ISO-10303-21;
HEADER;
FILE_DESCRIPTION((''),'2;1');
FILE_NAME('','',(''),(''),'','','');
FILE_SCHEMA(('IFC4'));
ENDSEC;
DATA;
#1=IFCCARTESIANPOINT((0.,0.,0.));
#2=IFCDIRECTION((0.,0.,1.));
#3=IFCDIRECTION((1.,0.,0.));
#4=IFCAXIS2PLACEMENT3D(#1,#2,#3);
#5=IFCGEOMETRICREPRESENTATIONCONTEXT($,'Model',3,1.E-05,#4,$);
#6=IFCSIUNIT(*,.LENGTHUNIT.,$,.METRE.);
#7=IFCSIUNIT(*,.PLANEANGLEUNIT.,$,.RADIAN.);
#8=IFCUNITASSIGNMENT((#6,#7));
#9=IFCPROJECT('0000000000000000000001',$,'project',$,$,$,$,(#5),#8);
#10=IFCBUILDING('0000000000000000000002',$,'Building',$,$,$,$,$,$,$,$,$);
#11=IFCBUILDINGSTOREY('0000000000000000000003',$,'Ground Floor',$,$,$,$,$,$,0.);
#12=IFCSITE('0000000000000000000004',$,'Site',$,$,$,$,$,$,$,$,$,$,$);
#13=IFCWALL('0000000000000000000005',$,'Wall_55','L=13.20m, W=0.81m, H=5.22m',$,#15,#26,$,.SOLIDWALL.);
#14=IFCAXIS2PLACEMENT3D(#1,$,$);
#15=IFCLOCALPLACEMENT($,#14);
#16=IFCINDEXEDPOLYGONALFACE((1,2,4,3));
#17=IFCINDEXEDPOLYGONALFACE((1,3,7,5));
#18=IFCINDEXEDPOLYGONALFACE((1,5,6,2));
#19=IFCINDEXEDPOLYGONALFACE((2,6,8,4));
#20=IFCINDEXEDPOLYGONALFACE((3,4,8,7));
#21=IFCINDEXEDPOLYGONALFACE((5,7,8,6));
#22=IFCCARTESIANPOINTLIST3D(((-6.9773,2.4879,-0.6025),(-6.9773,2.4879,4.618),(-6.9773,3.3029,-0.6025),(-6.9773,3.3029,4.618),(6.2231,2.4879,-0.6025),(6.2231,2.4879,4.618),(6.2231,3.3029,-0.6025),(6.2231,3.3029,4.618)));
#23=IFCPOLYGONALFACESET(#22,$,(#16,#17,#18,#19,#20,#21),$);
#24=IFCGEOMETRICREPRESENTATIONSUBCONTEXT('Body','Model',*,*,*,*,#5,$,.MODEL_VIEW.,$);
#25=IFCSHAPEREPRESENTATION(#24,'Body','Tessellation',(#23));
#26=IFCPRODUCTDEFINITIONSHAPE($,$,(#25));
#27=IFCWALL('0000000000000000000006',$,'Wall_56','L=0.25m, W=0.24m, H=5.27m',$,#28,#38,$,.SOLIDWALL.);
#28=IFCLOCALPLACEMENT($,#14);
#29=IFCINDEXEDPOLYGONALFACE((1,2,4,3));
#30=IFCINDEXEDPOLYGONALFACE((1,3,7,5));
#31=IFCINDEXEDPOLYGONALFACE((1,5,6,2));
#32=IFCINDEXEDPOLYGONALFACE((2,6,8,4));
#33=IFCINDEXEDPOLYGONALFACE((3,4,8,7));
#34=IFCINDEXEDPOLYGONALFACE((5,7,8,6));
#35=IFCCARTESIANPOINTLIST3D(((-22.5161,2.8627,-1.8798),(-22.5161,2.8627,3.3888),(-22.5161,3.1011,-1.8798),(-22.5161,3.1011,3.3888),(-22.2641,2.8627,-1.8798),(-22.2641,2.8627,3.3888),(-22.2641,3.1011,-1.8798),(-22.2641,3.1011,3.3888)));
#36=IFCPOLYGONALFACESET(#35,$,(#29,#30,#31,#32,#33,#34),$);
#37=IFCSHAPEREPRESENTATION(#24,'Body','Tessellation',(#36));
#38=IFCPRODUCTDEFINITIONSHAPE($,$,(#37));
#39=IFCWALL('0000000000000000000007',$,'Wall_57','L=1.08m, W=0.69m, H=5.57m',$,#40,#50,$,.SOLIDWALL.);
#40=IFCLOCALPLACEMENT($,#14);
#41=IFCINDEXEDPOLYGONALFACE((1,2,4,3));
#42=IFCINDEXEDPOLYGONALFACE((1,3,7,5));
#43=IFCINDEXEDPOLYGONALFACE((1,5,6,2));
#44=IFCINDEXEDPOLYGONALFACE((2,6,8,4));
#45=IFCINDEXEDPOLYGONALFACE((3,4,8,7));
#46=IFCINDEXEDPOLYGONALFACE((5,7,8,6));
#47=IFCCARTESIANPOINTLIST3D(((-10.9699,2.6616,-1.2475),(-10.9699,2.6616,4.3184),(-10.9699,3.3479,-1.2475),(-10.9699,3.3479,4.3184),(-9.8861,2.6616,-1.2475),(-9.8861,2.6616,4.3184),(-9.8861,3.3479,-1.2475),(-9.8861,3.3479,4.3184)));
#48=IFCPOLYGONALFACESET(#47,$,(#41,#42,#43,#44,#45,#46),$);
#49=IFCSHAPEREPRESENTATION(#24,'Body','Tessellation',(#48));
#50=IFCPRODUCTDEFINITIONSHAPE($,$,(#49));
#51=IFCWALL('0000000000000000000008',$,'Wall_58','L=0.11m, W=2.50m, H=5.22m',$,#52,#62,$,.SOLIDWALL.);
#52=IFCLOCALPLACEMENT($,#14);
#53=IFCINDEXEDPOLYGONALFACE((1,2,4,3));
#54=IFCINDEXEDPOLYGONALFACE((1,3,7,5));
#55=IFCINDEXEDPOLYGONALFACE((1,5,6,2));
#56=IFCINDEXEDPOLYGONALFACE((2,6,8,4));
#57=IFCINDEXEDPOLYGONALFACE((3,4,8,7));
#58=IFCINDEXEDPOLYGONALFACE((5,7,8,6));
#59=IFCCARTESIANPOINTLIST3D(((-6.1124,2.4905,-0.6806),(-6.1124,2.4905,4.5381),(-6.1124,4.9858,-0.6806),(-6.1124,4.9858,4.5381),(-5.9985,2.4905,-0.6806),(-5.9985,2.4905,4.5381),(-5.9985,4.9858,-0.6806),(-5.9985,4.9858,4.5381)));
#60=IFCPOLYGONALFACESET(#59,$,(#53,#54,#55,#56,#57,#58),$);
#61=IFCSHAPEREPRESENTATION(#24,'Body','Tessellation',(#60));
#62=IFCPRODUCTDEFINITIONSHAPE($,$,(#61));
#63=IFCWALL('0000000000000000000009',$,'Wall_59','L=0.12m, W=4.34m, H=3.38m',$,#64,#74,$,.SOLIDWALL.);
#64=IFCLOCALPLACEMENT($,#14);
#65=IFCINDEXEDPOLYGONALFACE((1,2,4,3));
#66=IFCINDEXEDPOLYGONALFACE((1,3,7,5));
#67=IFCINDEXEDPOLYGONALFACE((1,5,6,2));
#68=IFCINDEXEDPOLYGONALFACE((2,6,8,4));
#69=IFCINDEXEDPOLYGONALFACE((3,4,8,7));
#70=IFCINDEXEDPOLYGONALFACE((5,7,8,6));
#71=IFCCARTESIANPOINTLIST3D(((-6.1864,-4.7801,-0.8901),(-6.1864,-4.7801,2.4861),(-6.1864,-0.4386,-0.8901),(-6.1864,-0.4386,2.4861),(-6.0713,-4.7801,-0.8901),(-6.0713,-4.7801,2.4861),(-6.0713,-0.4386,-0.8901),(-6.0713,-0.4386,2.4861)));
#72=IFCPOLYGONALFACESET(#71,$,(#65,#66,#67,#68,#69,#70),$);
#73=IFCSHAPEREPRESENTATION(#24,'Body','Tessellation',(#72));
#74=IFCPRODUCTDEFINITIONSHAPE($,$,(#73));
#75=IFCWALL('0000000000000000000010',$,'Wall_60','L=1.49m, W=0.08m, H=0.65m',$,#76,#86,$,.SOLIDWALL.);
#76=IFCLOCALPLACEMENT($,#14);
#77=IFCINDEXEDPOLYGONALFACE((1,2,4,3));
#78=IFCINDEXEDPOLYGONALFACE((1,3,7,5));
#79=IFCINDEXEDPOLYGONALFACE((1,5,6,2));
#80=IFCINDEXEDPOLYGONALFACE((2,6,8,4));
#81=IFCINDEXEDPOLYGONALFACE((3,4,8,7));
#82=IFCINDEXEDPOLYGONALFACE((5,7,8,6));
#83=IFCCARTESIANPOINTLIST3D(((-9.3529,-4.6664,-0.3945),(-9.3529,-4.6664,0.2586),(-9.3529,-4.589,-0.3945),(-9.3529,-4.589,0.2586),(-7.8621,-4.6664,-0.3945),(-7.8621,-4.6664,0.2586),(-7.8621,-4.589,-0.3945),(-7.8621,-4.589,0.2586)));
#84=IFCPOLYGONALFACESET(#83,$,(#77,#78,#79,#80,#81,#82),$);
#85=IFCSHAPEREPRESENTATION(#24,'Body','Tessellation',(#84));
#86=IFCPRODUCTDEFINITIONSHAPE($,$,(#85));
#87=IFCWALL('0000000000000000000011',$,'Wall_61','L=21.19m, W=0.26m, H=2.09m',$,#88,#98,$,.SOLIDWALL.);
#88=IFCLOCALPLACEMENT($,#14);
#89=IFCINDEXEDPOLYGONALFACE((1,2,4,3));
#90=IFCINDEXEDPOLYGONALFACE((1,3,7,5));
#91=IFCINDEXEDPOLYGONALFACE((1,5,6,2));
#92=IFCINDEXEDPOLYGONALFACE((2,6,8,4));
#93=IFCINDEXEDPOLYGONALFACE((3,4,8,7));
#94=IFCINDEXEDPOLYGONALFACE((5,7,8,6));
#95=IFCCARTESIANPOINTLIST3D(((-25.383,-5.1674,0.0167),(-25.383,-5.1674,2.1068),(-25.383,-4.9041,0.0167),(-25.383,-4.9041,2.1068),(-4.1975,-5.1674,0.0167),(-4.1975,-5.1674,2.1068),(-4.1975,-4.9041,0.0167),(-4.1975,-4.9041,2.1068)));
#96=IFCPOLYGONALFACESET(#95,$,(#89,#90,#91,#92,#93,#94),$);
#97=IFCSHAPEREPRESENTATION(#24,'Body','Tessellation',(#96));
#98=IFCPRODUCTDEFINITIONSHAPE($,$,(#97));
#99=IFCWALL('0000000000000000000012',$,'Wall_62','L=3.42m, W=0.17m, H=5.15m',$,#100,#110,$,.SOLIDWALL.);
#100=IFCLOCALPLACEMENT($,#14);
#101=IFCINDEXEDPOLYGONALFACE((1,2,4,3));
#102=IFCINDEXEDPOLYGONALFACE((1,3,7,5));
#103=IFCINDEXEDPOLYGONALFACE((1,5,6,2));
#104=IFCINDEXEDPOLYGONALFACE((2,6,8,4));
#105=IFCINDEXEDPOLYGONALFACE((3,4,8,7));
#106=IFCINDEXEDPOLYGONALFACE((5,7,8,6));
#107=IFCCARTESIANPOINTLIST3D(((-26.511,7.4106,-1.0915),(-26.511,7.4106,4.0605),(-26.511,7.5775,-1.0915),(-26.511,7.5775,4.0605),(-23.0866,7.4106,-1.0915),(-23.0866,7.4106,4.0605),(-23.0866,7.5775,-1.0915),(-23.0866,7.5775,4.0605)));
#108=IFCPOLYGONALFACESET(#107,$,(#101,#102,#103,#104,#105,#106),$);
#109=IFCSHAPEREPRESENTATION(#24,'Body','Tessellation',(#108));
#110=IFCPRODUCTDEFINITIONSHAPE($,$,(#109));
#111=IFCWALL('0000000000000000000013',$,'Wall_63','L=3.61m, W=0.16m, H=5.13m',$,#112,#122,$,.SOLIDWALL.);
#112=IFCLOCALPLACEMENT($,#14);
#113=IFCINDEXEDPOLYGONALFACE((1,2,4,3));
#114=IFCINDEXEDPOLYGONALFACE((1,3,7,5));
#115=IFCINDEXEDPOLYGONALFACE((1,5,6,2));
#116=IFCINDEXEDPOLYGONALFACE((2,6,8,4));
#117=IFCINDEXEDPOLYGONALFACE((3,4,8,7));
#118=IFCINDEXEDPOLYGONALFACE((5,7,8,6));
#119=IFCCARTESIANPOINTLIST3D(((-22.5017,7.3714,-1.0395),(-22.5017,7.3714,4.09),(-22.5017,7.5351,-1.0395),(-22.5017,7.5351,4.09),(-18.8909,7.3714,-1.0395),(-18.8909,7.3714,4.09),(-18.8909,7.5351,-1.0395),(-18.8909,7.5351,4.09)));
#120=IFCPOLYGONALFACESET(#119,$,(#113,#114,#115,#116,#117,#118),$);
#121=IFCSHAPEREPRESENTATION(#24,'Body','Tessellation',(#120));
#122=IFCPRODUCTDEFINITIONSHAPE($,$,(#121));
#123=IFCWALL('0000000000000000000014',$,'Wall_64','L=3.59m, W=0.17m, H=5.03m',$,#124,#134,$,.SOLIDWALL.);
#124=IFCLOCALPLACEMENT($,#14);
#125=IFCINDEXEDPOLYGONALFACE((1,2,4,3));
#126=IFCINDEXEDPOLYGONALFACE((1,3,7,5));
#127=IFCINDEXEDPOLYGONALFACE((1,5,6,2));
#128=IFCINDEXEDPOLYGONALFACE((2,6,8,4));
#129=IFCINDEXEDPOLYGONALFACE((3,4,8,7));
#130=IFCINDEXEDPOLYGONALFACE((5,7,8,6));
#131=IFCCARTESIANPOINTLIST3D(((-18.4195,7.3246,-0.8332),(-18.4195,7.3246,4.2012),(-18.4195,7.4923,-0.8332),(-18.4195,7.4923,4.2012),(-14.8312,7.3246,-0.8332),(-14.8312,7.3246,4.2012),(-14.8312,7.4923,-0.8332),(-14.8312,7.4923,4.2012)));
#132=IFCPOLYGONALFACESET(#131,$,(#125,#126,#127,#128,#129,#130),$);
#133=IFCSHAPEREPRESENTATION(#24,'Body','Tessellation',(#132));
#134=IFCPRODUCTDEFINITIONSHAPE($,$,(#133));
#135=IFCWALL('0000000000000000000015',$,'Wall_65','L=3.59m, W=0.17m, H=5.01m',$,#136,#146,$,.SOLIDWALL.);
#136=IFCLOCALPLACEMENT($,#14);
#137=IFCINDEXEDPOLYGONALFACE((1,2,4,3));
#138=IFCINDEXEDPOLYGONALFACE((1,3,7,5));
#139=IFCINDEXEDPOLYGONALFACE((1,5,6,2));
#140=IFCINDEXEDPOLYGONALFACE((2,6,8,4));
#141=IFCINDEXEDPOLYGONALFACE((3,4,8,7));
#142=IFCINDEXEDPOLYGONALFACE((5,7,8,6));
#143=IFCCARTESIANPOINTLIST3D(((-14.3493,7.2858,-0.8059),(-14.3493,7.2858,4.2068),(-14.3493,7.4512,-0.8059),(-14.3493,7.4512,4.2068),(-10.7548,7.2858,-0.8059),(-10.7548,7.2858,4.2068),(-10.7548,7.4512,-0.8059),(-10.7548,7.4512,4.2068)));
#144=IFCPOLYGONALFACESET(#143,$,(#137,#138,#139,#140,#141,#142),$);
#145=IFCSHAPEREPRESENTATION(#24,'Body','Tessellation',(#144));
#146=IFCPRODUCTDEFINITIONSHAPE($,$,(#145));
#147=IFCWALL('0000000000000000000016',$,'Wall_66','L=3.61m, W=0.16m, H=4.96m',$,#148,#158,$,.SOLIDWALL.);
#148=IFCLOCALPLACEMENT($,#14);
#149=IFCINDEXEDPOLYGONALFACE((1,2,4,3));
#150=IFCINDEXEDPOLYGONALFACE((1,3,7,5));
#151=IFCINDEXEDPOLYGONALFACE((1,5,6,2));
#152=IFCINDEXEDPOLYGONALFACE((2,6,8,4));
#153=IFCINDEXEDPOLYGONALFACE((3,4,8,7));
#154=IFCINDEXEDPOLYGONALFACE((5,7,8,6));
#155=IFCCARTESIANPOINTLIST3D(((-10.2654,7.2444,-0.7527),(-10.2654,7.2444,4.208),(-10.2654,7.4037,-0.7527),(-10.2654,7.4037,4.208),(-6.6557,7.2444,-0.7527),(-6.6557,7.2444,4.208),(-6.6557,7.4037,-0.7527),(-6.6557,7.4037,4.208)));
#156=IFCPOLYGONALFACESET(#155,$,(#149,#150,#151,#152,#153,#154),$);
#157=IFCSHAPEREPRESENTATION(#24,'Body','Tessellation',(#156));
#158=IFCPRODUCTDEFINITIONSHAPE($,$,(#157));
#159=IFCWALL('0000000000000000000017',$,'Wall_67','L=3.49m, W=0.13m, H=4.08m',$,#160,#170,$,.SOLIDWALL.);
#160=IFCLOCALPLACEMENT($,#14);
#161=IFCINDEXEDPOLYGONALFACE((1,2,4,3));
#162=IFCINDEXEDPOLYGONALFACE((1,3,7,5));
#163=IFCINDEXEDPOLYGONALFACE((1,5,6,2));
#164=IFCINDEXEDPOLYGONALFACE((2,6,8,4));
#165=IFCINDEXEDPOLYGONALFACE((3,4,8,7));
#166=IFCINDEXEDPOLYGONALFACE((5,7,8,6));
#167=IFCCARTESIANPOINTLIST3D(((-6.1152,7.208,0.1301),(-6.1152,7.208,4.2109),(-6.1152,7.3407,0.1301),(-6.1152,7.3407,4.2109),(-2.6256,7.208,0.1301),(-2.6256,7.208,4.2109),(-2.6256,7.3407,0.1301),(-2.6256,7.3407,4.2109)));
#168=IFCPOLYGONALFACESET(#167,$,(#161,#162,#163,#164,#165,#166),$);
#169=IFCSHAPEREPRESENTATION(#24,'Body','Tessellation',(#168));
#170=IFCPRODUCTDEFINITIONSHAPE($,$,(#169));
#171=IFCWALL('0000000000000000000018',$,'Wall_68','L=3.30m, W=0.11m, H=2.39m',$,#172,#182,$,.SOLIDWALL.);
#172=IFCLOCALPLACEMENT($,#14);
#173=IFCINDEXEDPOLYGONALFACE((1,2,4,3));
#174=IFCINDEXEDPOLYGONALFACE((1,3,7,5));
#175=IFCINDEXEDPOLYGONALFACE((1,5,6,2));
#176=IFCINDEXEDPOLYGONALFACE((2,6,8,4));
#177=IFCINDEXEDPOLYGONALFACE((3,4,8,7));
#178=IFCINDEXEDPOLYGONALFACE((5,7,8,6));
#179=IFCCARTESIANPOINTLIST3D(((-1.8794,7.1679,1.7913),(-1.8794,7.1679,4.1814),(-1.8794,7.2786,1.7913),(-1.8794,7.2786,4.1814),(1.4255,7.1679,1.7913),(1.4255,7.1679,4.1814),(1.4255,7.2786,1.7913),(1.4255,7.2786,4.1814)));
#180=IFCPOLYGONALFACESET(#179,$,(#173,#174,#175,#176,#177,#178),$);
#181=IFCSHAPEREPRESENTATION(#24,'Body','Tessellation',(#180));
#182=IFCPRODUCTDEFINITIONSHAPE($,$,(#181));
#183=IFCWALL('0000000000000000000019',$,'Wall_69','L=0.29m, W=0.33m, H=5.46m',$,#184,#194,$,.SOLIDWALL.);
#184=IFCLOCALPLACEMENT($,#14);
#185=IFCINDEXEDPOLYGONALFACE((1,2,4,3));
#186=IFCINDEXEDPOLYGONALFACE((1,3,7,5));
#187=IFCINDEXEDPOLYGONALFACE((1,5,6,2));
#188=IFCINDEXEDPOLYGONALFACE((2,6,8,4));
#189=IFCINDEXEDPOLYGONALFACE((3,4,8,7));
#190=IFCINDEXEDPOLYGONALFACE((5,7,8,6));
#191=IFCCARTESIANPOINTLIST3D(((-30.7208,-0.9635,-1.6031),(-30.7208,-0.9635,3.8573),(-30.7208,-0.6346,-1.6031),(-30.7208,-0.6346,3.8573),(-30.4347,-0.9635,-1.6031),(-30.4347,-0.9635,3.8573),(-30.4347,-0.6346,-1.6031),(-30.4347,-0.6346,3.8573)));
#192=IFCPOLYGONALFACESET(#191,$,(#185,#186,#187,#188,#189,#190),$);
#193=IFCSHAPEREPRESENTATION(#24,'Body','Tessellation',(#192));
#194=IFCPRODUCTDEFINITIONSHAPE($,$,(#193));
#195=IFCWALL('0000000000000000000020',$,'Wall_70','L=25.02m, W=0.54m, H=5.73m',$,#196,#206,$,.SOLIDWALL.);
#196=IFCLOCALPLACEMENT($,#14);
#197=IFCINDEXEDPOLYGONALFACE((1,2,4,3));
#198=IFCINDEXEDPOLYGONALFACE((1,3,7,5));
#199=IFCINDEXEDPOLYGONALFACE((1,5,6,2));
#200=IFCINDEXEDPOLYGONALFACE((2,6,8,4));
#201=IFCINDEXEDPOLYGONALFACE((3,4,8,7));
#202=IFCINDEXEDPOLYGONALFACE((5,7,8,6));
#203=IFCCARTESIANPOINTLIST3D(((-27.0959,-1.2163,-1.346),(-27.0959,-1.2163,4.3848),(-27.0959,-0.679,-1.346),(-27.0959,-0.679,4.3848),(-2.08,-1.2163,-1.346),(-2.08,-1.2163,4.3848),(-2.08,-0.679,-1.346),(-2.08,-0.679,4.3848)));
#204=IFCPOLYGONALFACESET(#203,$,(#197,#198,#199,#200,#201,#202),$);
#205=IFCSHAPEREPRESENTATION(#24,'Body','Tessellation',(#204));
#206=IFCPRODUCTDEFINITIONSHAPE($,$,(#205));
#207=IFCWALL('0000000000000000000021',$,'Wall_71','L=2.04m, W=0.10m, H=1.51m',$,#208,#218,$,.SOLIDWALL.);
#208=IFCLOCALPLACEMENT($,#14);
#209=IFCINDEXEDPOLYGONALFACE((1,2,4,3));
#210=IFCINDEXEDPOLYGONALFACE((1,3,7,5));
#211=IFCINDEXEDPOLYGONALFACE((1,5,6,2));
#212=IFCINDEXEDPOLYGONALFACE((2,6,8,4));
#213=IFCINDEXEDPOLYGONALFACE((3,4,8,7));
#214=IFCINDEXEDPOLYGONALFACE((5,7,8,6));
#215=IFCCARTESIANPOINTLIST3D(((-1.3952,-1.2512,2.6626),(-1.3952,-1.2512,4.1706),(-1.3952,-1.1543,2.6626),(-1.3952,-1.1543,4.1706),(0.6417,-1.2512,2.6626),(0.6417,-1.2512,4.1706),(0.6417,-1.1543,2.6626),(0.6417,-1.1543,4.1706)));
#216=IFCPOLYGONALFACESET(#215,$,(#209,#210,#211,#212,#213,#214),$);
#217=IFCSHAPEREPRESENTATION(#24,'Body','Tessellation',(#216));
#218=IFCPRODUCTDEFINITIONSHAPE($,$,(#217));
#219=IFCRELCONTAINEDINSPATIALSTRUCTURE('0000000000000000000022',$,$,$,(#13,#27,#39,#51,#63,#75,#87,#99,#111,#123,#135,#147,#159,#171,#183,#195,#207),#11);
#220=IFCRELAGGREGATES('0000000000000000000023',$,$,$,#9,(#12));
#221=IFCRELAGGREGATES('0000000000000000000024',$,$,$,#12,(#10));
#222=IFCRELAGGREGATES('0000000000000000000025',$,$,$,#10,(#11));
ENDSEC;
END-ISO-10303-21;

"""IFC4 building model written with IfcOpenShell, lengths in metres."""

from ifc_helpers import new_model, si_unit, frame, origin_with_axes, origin_2d, context, subcontext, project, spatial, rectangle, extrude, element, save


model = new_model("IFC4")

# Units and contexts
model_context = context("Model", 3, precision=1e-05, world=origin_with_axes())
body_context = subcontext(model_context, "Body", "Model", "MODEL_VIEW")
ifc_project = project(units=[si_unit("LENGTHUNIT", "METRE"), si_unit("PLANEANGLEUNIT", "RADIAN")], contexts=[model_context])

# Site, building, storey
site = spatial("IfcSite", under=ifc_project, Name="Site")
building = spatial("IfcBuilding", under=site, Name="Building")
storey = spatial("IfcBuildingStorey", under=building, Name="Ground Floor", Elevation=0.0)

# Walls
element("IfcWall", 1, inside=storey, Name="Wall_55", Description="L=13.20m, W=0.81m, H=5.22m", PredefinedType="SOLIDWALL", context=body_context, shape_type="SweptSolid", body=[
    extrude(rectangle(XDim=13.2003, YDim=0.815, at=origin_2d()), frame((-0.3771, 2.8954, -0.6025), z_axis=(0.0, 0.0, 1.0), x_axis=(1.0, 0.0, 0.0)), (0.0, 0.0, 1.0), 5.2206),
])
element("IfcWall", 2, inside=storey, Name="Wall_56", Description="L=0.25m, W=0.24m, H=5.27m", PredefinedType="SOLIDWALL", context=body_context, shape_type="SweptSolid", body=[
    extrude(rectangle(XDim=0.252, YDim=0.2384, at=origin_2d()), frame((-22.3901, 2.9819, -1.8798), z_axis=(0.0, 0.0, 1.0), x_axis=(1.0, 0.0, 0.0)), (0.0, 0.0, 1.0), 5.2687),
])
element("IfcWall", 3, inside=storey, Name="Wall_57", Description="L=1.08m, W=0.69m, H=5.57m", PredefinedType="SOLIDWALL", context=body_context, shape_type="SweptSolid", body=[
    extrude(rectangle(XDim=1.0838, YDim=0.6863, at=origin_2d()), frame((-10.428, 3.0048, -1.2475), z_axis=(0.0, 0.0, 1.0), x_axis=(1.0, 0.0, 0.0)), (0.0, 0.0, 1.0), 5.5659),
])
element("IfcWall", 4, inside=storey, Name="Wall_58", Description="L=0.11m, W=2.50m, H=5.22m", PredefinedType="SOLIDWALL", context=body_context, shape_type="SweptSolid", body=[
    extrude(rectangle(XDim=0.114, YDim=2.4953, at=origin_2d()), frame((-6.0555, 3.7382, -0.6806), z_axis=(0.0, 0.0, 1.0), x_axis=(1.0, 0.0, 0.0)), (0.0, 0.0, 1.0), 5.2186),
])
element("IfcWall", 5, inside=storey, Name="Wall_59", Description="L=0.12m, W=4.34m, H=3.38m", PredefinedType="SOLIDWALL", context=body_context, shape_type="SweptSolid", body=[
    extrude(rectangle(XDim=0.1151, YDim=4.3415, at=origin_2d()), frame((-6.1289, -2.6094, -0.8901), z_axis=(0.0, 0.0, 1.0), x_axis=(1.0, 0.0, 0.0)), (0.0, 0.0, 1.0), 3.3762),
])
element("IfcWall", 6, inside=storey, Name="Wall_60", Description="L=1.49m, W=0.08m, H=0.65m", PredefinedType="SOLIDWALL", context=body_context, shape_type="SweptSolid", body=[
    extrude(rectangle(XDim=1.4908, YDim=0.0774, at=origin_2d()), frame((-8.6075, -4.6277, -0.3945), z_axis=(0.0, 0.0, 1.0), x_axis=(1.0, 0.0, 0.0)), (0.0, 0.0, 1.0), 0.6531),
])
element("IfcWall", 7, inside=storey, Name="Wall_61", Description="L=21.19m, W=0.26m, H=2.09m", PredefinedType="SOLIDWALL", context=body_context, shape_type="SweptSolid", body=[
    extrude(rectangle(XDim=21.1854, YDim=0.2632, at=origin_2d()), frame((-14.7902, -5.0357, 0.0167), z_axis=(0.0, 0.0, 1.0), x_axis=(1.0, 0.0, 0.0)), (0.0, 0.0, 1.0), 2.0901),
])
element("IfcWall", 8, inside=storey, Name="Wall_62", Description="L=3.42m, W=0.17m, H=5.15m", PredefinedType="SOLIDWALL", context=body_context, shape_type="SweptSolid", body=[
    extrude(rectangle(XDim=3.4244, YDim=0.1669, at=origin_2d()), frame((-24.7988, 7.494, -1.0915), z_axis=(0.0, 0.0, 1.0), x_axis=(1.0, 0.0, 0.0)), (0.0, 0.0, 1.0), 5.152),
])
element("IfcWall", 9, inside=storey, Name="Wall_63", Description="L=3.61m, W=0.16m, H=5.13m", PredefinedType="SOLIDWALL", context=body_context, shape_type="SweptSolid", body=[
    extrude(rectangle(XDim=3.6108, YDim=0.1637, at=origin_2d()), frame((-20.6963, 7.4533, -1.0395), z_axis=(0.0, 0.0, 1.0), x_axis=(1.0, 0.0, 0.0)), (0.0, 0.0, 1.0), 5.1295),
])
element("IfcWall", 10, inside=storey, Name="Wall_64", Description="L=3.59m, W=0.17m, H=5.03m", PredefinedType="SOLIDWALL", context=body_context, shape_type="SweptSolid", body=[
    extrude(rectangle(XDim=3.5883, YDim=0.1677, at=origin_2d()), frame((-16.6253, 7.4085, -0.8332), z_axis=(0.0, 0.0, 1.0), x_axis=(1.0, 0.0, 0.0)), (0.0, 0.0, 1.0), 5.0343),
])
element("IfcWall", 11, inside=storey, Name="Wall_65", Description="L=3.59m, W=0.17m, H=5.01m", PredefinedType="SOLIDWALL", context=body_context, shape_type="SweptSolid", body=[
    extrude(rectangle(XDim=3.5945, YDim=0.1655, at=origin_2d()), frame((-12.552, 7.3685, -0.8059), z_axis=(0.0, 0.0, 1.0), x_axis=(1.0, 0.0, 0.0)), (0.0, 0.0, 1.0), 5.0127),
])
element("IfcWall", 12, inside=storey, Name="Wall_66", Description="L=3.61m, W=0.16m, H=4.96m", PredefinedType="SOLIDWALL", context=body_context, shape_type="SweptSolid", body=[
    extrude(rectangle(XDim=3.6097, YDim=0.1593, at=origin_2d()), frame((-8.4605, 7.324, -0.7527), z_axis=(0.0, 0.0, 1.0), x_axis=(1.0, 0.0, 0.0)), (0.0, 0.0, 1.0), 4.9606),
])
element("IfcWall", 13, inside=storey, Name="Wall_67", Description="L=3.49m, W=0.13m, H=4.08m", PredefinedType="SOLIDWALL", context=body_context, shape_type="SweptSolid", body=[
    extrude(rectangle(XDim=3.4897, YDim=0.1327, at=origin_2d()), frame((-4.3704, 7.2743, 0.1301), z_axis=(0.0, 0.0, 1.0), x_axis=(1.0, 0.0, 0.0)), (0.0, 0.0, 1.0), 4.0809),
])
element("IfcWall", 14, inside=storey, Name="Wall_68", Description="L=3.30m, W=0.11m, H=2.39m", PredefinedType="SOLIDWALL", context=body_context, shape_type="SweptSolid", body=[
    extrude(rectangle(XDim=3.305, YDim=0.1107, at=origin_2d()), frame((-0.227, 7.2232, 1.7913), z_axis=(0.0, 0.0, 1.0), x_axis=(1.0, 0.0, 0.0)), (0.0, 0.0, 1.0), 2.3901),
])
element("IfcWall", 15, inside=storey, Name="Wall_69", Description="L=0.29m, W=0.33m, H=5.46m", PredefinedType="SOLIDWALL", context=body_context, shape_type="SweptSolid", body=[
    extrude(rectangle(XDim=0.2861, YDim=0.3289, at=origin_2d()), frame((-30.5778, -0.799, -1.6031), z_axis=(0.0, 0.0, 1.0), x_axis=(1.0, 0.0, 0.0)), (0.0, 0.0, 1.0), 5.4605),
])
element("IfcWall", 16, inside=storey, Name="Wall_70", Description="L=25.02m, W=0.54m, H=5.73m", PredefinedType="SOLIDWALL", context=body_context, shape_type="SweptSolid", body=[
    extrude(rectangle(XDim=25.0159, YDim=0.5374, at=origin_2d()), frame((-14.5879, -0.9476, -1.346), z_axis=(0.0, 0.0, 1.0), x_axis=(1.0, 0.0, 0.0)), (0.0, 0.0, 1.0), 5.7308),
])
element("IfcWall", 17, inside=storey, Name="Wall_71", Description="L=2.04m, W=0.10m, H=1.51m", PredefinedType="SOLIDWALL", context=body_context, shape_type="SweptSolid", body=[
    extrude(rectangle(XDim=2.037, YDim=0.097, at=origin_2d()), frame((-0.3768, -1.2027, 2.6626), z_axis=(0.0, 0.0, 1.0), x_axis=(1.0, 0.0, 0.0)), (0.0, 0.0, 1.0), 1.5081),
])

save(model, "model.ifc")
